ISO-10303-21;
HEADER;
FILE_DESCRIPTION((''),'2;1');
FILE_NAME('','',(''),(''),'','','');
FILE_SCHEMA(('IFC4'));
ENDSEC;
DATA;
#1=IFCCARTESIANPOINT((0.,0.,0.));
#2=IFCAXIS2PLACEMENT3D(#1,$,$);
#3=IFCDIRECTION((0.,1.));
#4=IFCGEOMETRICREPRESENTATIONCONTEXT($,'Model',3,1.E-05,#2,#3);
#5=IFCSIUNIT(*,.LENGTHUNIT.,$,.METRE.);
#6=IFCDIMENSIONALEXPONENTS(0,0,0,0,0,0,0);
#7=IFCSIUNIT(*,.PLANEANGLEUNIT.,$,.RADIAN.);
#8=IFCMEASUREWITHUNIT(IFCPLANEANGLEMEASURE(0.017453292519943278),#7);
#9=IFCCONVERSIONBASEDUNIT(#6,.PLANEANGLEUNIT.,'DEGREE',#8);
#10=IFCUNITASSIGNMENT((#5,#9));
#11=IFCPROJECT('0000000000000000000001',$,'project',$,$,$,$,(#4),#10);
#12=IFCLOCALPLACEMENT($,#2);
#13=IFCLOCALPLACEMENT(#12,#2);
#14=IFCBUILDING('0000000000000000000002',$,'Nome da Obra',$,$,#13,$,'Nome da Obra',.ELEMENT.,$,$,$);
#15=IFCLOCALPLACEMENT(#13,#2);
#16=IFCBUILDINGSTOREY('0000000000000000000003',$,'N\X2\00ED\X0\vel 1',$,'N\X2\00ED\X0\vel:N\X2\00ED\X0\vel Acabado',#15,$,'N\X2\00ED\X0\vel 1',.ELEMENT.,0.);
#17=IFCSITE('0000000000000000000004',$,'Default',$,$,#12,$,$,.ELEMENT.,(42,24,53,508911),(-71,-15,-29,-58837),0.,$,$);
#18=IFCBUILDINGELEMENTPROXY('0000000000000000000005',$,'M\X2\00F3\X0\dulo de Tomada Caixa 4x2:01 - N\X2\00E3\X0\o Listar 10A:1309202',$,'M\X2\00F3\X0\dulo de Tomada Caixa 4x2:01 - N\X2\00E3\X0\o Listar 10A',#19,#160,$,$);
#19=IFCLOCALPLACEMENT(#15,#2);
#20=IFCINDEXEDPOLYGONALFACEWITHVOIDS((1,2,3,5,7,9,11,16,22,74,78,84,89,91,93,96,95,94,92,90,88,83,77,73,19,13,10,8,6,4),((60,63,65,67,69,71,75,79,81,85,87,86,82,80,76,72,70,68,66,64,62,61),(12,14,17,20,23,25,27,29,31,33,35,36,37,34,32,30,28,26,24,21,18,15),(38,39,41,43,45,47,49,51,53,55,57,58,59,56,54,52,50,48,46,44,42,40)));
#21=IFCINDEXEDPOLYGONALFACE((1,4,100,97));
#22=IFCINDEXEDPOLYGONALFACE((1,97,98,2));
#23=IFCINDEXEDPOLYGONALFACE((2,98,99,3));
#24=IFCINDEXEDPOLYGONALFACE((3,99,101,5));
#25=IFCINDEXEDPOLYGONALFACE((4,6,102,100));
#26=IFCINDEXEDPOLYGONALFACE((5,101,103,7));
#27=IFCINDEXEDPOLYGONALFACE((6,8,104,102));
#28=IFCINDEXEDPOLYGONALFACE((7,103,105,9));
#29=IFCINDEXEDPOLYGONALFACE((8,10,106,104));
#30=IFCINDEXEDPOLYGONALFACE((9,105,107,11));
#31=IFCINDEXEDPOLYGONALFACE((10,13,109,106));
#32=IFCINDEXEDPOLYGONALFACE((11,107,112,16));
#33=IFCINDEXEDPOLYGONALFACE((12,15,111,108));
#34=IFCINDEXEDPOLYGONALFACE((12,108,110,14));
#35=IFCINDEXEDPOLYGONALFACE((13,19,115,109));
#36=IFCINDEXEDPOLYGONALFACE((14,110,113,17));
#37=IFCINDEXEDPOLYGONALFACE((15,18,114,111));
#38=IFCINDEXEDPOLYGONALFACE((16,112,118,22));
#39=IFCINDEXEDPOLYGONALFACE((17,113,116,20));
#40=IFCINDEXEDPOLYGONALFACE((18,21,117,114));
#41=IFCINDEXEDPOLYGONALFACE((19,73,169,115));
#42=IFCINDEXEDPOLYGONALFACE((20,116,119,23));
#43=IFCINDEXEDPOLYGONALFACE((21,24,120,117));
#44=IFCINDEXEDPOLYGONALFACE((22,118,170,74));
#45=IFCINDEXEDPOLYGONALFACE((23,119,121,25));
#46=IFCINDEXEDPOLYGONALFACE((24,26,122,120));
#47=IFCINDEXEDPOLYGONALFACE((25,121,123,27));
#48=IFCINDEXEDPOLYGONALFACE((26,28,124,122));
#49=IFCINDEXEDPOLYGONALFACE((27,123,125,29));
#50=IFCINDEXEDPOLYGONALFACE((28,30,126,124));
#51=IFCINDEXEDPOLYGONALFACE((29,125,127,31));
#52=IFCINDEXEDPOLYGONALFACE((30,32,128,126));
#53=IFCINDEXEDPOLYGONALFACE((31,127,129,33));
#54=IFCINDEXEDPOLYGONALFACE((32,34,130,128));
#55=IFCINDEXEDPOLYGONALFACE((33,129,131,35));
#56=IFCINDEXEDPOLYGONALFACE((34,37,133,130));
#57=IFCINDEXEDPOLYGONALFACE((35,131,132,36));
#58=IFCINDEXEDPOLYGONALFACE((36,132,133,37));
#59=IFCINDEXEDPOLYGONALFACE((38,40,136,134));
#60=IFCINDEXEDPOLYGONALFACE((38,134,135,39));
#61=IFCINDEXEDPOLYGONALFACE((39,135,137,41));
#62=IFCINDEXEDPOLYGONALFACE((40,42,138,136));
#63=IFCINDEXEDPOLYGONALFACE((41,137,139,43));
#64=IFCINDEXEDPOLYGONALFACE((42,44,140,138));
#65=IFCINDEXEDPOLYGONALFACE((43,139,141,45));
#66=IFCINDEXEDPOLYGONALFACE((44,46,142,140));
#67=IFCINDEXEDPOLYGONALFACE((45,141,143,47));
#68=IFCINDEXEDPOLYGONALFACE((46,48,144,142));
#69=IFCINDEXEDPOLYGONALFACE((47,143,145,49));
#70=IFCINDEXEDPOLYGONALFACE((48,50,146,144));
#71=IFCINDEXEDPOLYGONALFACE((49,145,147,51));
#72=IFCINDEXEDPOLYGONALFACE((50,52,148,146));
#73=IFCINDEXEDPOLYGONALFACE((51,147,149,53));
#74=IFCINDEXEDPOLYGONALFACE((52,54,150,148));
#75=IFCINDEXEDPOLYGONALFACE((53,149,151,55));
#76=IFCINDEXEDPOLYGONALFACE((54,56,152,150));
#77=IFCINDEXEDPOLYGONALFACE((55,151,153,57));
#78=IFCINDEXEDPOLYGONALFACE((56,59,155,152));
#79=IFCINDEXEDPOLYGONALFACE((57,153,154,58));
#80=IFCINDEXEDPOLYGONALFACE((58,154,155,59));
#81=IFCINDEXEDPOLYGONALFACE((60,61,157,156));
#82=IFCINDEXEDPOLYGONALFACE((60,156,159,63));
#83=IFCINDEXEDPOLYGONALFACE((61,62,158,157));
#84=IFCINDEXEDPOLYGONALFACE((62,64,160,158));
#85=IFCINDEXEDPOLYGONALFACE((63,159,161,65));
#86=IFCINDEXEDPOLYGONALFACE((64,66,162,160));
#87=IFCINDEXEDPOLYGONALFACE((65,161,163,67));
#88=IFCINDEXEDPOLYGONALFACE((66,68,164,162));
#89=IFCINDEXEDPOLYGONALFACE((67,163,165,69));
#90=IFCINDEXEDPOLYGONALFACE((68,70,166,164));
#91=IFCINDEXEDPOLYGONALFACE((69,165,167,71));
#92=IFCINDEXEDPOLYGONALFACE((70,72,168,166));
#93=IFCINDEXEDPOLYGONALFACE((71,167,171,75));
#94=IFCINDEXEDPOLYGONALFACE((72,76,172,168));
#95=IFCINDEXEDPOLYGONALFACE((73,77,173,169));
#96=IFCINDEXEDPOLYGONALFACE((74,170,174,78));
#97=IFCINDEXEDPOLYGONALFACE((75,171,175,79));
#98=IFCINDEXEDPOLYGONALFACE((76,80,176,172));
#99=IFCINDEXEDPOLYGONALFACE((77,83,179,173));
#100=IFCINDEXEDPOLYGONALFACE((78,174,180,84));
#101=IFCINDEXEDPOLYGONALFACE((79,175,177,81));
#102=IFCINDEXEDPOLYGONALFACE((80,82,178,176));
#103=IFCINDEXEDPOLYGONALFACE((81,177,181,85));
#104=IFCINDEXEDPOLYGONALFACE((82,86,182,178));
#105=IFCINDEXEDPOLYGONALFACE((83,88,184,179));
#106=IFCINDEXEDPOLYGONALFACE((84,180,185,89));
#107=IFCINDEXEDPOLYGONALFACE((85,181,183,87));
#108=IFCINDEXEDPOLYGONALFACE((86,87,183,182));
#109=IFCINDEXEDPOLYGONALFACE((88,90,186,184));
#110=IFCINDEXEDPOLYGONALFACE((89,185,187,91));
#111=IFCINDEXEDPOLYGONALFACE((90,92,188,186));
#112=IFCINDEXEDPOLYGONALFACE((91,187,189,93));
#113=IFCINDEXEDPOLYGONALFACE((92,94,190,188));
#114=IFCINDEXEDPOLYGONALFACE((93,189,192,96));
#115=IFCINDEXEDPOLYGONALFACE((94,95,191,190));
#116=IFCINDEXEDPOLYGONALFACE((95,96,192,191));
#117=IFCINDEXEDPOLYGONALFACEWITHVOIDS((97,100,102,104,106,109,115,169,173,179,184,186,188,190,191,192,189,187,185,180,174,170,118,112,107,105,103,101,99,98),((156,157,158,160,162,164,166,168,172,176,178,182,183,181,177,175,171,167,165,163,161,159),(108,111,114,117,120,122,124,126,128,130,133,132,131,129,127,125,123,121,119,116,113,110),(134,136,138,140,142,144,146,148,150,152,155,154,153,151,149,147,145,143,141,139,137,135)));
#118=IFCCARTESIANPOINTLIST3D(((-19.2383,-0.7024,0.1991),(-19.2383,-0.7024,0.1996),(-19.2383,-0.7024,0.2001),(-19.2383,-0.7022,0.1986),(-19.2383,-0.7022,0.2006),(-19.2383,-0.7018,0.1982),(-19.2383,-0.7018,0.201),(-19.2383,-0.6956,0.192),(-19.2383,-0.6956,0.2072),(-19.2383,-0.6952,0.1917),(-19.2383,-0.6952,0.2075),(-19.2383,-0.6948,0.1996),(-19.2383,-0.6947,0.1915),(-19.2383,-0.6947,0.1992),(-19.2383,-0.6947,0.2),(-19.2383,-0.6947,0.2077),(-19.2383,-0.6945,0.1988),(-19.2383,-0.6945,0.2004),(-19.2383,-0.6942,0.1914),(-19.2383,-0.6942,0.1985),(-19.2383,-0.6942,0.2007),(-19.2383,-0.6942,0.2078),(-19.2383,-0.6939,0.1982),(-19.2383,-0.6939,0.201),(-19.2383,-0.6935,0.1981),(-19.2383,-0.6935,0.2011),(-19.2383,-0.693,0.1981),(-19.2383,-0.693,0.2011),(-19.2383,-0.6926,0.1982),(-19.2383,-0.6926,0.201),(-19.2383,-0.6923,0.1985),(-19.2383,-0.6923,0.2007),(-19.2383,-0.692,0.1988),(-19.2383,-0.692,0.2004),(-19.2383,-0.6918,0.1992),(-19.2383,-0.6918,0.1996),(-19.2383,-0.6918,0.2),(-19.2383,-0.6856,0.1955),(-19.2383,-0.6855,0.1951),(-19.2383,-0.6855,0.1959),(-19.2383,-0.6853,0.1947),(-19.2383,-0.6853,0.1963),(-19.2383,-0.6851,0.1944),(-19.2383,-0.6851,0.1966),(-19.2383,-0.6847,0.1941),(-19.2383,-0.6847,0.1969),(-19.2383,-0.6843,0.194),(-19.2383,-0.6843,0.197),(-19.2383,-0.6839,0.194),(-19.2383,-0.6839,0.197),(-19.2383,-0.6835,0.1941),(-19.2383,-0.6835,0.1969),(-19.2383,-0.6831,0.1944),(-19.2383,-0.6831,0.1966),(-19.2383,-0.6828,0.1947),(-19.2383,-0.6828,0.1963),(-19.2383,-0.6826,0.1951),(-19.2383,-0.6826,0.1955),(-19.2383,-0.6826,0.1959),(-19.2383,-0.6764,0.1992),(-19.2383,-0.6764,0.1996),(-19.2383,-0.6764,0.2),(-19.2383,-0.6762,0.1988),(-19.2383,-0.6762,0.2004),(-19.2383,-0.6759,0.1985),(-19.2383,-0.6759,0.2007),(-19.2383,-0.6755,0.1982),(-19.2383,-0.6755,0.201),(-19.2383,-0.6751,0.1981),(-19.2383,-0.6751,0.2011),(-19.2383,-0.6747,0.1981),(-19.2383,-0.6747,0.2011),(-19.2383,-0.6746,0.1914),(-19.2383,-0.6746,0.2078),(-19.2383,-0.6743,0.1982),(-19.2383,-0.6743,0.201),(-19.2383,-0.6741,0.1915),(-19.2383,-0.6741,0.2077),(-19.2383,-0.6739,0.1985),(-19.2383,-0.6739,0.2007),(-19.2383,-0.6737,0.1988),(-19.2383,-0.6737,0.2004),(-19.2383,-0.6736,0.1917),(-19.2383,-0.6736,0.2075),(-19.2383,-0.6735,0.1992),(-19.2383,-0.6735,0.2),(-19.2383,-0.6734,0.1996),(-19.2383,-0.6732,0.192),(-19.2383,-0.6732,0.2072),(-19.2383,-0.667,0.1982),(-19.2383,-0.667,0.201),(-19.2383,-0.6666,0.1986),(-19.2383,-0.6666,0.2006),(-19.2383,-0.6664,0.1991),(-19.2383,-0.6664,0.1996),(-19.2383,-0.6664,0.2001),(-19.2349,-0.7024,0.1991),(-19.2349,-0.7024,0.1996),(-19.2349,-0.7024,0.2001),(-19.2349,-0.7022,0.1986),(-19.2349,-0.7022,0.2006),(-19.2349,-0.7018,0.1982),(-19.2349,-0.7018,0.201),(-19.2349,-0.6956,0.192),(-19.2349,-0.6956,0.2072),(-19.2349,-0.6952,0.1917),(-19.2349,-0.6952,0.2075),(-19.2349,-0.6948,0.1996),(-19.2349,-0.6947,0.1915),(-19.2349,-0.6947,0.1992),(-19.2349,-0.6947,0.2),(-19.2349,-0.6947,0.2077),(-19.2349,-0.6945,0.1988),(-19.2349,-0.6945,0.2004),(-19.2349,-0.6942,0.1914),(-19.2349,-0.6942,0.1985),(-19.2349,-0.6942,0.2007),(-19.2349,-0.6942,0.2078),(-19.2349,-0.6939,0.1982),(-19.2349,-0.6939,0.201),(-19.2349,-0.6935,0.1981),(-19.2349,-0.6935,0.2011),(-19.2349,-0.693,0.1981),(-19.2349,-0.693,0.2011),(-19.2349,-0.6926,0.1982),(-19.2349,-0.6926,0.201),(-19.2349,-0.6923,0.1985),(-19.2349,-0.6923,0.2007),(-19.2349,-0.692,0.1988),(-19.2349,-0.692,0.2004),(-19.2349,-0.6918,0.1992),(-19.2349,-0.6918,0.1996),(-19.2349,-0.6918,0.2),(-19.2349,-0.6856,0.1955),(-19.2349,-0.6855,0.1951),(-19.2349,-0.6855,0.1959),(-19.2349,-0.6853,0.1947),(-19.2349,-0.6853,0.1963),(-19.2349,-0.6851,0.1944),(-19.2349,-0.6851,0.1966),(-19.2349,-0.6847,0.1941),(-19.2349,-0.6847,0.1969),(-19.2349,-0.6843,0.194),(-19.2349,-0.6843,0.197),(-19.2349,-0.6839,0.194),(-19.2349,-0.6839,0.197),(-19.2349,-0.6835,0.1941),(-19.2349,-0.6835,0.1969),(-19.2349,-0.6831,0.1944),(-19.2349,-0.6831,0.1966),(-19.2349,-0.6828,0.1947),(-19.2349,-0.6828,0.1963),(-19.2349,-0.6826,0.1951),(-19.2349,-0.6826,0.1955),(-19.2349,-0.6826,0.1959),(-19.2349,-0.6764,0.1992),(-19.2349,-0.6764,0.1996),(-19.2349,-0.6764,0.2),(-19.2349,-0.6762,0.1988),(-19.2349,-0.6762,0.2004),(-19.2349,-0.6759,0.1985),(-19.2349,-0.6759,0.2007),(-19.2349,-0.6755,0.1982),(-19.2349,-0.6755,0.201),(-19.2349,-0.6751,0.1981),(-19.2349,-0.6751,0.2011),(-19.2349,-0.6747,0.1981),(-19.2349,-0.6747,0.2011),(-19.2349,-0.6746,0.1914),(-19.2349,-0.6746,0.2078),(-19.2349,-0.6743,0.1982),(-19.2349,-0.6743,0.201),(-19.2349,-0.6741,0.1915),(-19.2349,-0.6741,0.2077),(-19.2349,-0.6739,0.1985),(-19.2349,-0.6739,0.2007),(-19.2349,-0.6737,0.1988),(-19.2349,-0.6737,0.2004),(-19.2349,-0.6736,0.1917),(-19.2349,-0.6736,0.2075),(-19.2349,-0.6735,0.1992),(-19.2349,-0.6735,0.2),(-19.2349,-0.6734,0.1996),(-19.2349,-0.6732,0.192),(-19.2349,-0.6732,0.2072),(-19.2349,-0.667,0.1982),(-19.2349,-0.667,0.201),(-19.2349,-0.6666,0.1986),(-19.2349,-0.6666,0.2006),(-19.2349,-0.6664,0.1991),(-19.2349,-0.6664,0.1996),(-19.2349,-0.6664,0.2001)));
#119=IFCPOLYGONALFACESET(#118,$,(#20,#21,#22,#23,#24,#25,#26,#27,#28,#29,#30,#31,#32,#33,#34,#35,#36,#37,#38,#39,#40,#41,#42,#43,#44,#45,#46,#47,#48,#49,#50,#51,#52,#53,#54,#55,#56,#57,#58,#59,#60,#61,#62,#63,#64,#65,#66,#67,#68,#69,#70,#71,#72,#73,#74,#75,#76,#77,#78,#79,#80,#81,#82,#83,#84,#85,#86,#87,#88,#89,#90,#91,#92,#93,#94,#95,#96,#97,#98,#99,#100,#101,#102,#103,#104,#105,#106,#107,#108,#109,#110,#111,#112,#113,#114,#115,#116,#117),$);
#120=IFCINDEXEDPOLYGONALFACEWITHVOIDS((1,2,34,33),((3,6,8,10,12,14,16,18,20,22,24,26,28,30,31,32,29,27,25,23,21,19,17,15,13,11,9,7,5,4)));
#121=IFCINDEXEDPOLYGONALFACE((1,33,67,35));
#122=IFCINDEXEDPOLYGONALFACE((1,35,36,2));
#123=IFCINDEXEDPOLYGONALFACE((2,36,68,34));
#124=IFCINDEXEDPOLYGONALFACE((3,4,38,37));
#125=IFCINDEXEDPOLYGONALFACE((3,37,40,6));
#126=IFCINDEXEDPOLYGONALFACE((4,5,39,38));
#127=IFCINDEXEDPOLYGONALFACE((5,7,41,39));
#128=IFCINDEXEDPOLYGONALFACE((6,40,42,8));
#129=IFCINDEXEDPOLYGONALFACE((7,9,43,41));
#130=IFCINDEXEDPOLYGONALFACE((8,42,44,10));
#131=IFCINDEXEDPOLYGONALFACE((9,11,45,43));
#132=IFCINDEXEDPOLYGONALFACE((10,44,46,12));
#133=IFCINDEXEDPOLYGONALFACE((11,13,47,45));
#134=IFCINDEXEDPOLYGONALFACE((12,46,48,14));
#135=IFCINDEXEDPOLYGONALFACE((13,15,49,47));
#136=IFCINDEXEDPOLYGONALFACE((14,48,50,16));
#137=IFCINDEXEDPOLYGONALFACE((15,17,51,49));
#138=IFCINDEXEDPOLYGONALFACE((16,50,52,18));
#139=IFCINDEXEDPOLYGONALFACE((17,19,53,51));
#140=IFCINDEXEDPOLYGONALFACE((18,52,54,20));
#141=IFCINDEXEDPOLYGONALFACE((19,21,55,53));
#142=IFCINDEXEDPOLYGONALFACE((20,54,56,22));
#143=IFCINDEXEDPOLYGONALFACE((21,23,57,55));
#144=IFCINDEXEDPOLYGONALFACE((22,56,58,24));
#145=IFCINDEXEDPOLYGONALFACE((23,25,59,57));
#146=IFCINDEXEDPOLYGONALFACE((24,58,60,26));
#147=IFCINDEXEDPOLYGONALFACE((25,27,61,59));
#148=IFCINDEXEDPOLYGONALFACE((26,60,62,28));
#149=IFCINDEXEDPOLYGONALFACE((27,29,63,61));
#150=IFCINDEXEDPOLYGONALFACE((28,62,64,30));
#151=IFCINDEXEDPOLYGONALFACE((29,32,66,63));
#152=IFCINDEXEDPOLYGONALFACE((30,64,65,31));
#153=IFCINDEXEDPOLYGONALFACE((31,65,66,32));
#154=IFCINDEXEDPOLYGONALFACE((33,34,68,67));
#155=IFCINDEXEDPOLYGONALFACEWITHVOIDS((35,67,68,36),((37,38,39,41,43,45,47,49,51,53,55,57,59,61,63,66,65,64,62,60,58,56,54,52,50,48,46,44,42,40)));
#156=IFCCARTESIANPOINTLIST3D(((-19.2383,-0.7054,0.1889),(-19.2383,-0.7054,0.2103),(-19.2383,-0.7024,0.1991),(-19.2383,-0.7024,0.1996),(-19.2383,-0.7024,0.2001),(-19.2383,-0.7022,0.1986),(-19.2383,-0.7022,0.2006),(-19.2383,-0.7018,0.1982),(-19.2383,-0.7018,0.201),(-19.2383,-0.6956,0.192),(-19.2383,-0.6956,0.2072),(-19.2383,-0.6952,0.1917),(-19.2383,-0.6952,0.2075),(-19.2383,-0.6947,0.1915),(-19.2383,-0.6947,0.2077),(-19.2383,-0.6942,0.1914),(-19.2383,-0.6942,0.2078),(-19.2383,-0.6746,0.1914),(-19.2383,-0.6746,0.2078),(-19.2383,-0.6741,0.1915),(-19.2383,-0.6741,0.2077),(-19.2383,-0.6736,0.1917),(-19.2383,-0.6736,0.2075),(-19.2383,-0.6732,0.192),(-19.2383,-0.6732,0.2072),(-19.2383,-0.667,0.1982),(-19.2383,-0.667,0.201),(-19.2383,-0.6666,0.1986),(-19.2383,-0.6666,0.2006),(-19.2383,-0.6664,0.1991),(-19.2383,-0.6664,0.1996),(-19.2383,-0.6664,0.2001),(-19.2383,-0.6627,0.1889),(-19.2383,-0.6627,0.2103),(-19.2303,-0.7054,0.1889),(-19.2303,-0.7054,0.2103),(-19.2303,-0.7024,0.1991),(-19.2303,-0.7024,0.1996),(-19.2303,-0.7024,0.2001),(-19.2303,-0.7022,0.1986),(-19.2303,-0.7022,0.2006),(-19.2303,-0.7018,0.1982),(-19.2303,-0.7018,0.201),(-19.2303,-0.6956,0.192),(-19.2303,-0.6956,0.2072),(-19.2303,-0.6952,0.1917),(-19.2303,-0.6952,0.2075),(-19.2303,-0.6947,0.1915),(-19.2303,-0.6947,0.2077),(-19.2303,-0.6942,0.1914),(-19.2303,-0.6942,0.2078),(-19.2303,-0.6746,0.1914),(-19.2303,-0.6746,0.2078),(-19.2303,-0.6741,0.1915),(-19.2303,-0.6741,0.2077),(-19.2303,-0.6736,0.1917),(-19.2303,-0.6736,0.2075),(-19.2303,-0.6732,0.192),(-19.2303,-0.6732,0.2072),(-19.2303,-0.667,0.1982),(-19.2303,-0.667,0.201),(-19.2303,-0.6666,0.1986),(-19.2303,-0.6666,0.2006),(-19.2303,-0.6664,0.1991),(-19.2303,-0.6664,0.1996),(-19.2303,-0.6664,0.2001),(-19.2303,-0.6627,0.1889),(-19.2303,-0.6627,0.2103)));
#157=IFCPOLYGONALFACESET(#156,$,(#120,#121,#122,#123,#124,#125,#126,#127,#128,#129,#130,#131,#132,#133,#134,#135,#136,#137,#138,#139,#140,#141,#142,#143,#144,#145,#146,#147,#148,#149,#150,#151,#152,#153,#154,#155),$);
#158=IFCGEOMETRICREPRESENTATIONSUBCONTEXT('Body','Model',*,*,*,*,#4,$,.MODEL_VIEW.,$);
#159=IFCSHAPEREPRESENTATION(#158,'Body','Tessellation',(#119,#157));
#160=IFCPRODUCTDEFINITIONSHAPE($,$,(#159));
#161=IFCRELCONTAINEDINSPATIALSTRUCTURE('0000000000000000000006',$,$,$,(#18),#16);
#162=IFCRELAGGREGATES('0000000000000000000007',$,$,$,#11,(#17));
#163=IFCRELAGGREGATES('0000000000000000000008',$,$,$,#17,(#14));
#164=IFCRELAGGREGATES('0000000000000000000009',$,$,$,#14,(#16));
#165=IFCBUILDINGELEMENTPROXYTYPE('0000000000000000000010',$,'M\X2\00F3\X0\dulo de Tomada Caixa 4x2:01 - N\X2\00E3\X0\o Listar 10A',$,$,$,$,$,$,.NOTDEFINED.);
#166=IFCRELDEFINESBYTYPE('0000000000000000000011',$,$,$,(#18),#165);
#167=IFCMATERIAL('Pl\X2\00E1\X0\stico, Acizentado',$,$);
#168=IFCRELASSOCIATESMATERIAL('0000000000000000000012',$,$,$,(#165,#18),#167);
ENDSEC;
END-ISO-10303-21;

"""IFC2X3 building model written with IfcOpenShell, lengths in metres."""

from ifc_helpers import new_model, entity, si_unit, converted_unit, direction, frame, frame_2d, origin, place, context, subcontext, project, spatial, polyline, circle_curve, parameter, trimmed, segment, composite_curve, outline, extrude, source, transform, mapped, material, type_object, type_shapes, element, save


model = new_model("IFC2X3")

# Units and contexts
model_context = context("Model", 3, precision=1e-05, world=origin(), true_north=direction((0.0, 1.0)))
body_context = subcontext(model_context, "Body", "Model", "MODEL_VIEW")
ifc_project = project(units=[si_unit("LENGTHUNIT", "METRE"), converted_unit("PLANEANGLEUNIT", "DEGREE", entity("IfcPlaneAngleMeasure", 0.017453292519943278), si_unit("PLANEANGLEUNIT", "RADIAN"), dimensions=[0, 0, 0, 0, 0, 0, 0])], contexts=[model_context])

# Site, building, storey
site_placement = place(None, origin())
site = spatial("IfcSite", under=ifc_project, at=site_placement, Name="Default", CompositionType="ELEMENT", RefLatitude=(42, 24, 53, 508911), RefLongitude=(-71, -15, -29, -58837), RefElevation=0.0)
building_placement = place(site_placement, origin())
building = spatial("IfcBuilding", under=site, at=building_placement, Name="Nome da Obra", LongName="Nome da Obra", CompositionType="ELEMENT")
storey_placement = place(building_placement, origin())
storey = spatial("IfcBuildingStorey", under=building, at=storey_placement, Name="Nível 1", ObjectType="Nível:Nível Acabado", LongName="Nível 1", CompositionType="ELEMENT", Elevation=0.0)

# Building element proxy
ifc_material_1 = material(Name="Plástico, Acizentado")
building_element_proxy_type_1 = type_object("IfcBuildingElementProxyType", Name="Módulo de Tomada Caixa 4x2:01 - Não Listar 10A", PredefinedType="NOTDEFINED", material=ifc_material_1)
shared_shape_1 = source(origin(), body_context, "Body", "SweptSolid", [
    extrude(outline(composite_curve([segment(polyline([(-0.0098, -0.0082), (0.0098, -0.0082)]), True, "CONTINUOUS"), segment(trimmed(circle_curve(frame_2d((0.0098, -0.0062), x_axis=(1.0, 0.0)), 0.002), [parameter(270.0)], [parameter(315.0)], True, "PARAMETER"), True, "CONTINUOUS"), segment(polyline([(0.0112, -0.0076), (0.0174, -0.0014)]), True, "CONTINUOUS"), segment(trimmed(circle_curve(frame_2d((0.016, 0.0), x_axis=(1.0, 0.0)), 0.002), [parameter(315.0)], [parameter(45.0)], True, "PARAMETER"), True, "CONTINUOUS"), segment(polyline([(0.0174, 0.0014), (0.0112, 0.0076)]), True, "CONTINUOUS"), segment(trimmed(circle_curve(frame_2d((0.0098, 0.0062), x_axis=(1.0, 0.0)), 0.002), [parameter(45.0)], [parameter(90.0)], True, "PARAMETER"), True, "CONTINUOUS"), segment(polyline([(0.0098, 0.0082), (-0.0098, 0.0082)]), True, "CONTINUOUS"), segment(trimmed(circle_curve(frame_2d((-0.0098, 0.0062), x_axis=(1.0, 0.0)), 0.002), [parameter(90.0)], [parameter(135.0)], True, "PARAMETER"), True, "CONTINUOUS"), segment(polyline([(-0.0112, 0.0076), (-0.0174, 0.0014)]), True, "CONTINUOUS"), segment(trimmed(circle_curve(frame_2d((-0.016, 0.0), x_axis=(1.0, 0.0)), 0.002), [parameter(135.0)], [parameter(225.0)], True, "PARAMETER"), True, "CONTINUOUS"), segment(polyline([(-0.0174, -0.0014), (-0.0112, -0.0076)]), True, "CONTINUOUS"), segment(trimmed(circle_curve(frame_2d((-0.0098, -0.0062), x_axis=(1.0, 0.0)), 0.002), [parameter(225.0)], [parameter(270.0)], True, "PARAMETER"), True, "CONTINUOUS")], self_intersect=False), holes=[composite_curve([segment(trimmed(circle_curve(frame_2d((0.0089, 0.0), x_axis=(1.0, 0.0)), 0.0015), [parameter(0.0)], [parameter(180.0)], True, "PARAMETER"), False, "CONTINUOUS"), segment(trimmed(circle_curve(frame_2d((0.0089, 0.0), x_axis=(1.0, 0.0)), 0.0015), [parameter(180.0)], [parameter(0.0)], True, "PARAMETER"), False, "CONTINUOUS")], self_intersect=False), composite_curve([segment(trimmed(circle_curve(frame_2d((-0.0003, 0.0041), x_axis=(1.0, 0.0)), 0.0015), [parameter(0.0)], [parameter(180.0)], True, "PARAMETER"), False, "CONTINUOUS"), segment(trimmed(circle_curve(frame_2d((-0.0003, 0.0041), x_axis=(1.0, 0.0)), 0.0015), [parameter(180.0)], [parameter(0.0)], True, "PARAMETER"), False, "CONTINUOUS")], self_intersect=False), composite_curve([segment(trimmed(circle_curve(frame_2d((-0.0095, 0.0), x_axis=(1.0, 0.0)), 0.0015), [parameter(0.0)], [parameter(180.0)], True, "PARAMETER"), False, "CONTINUOUS"), segment(trimmed(circle_curve(frame_2d((-0.0095, 0.0), x_axis=(1.0, 0.0)), 0.0015), [parameter(180.0)], [parameter(0.0)], True, "PARAMETER"), False, "CONTINUOUS")], self_intersect=False)]), frame((0.0003, 0.0, 0.125), z_axis=(0.0, 1.0, 0.0), x_axis=(1.0, 0.0, 0.0)), (0.0, 0.0, 1.0), 0.0034),
    extrude(outline(polyline([(-0.0214, -0.0107), (0.0214, -0.0107), (0.0214, 0.0107), (-0.0214, 0.0107), (-0.0214, -0.0107)]), holes=[composite_curve([segment(polyline([(0.0101, -0.0082), (-0.0095, -0.0082)]), True, "CONTINUOUS"), segment(trimmed(circle_curve(frame_2d((-0.0095, -0.0062), x_axis=(1.0, 0.0)), 0.002), [parameter(225.0)], [parameter(270.0)], True, "PARAMETER"), False, "CONTINUOUS"), segment(polyline([(-0.0109, -0.0076), (-0.0171, -0.0014)]), True, "CONTINUOUS"), segment(trimmed(circle_curve(frame_2d((-0.0157, 0.0), x_axis=(1.0, 0.0)), 0.002), [parameter(135.0)], [parameter(225.0)], True, "PARAMETER"), False, "CONTINUOUS"), segment(polyline([(-0.0171, 0.0014), (-0.0109, 0.0076)]), True, "CONTINUOUS"), segment(trimmed(circle_curve(frame_2d((-0.0095, 0.0062), x_axis=(1.0, 0.0)), 0.002), [parameter(90.0)], [parameter(135.0)], True, "PARAMETER"), False, "CONTINUOUS"), segment(polyline([(-0.0095, 0.0082), (0.0101, 0.0082)]), True, "CONTINUOUS"), segment(trimmed(circle_curve(frame_2d((0.0101, 0.0062), x_axis=(1.0, 0.0)), 0.002), [parameter(45.0)], [parameter(90.0)], True, "PARAMETER"), False, "CONTINUOUS"), segment(polyline([(0.0115, 0.0076), (0.0177, 0.0014)]), True, "CONTINUOUS"), segment(trimmed(circle_curve(frame_2d((0.0163, 0.0), x_axis=(1.0, 0.0)), 0.002), [parameter(315.0)], [parameter(45.0)], True, "PARAMETER"), False, "CONTINUOUS"), segment(polyline([(0.0177, -0.0014), (0.0115, -0.0076)]), True, "CONTINUOUS"), segment(trimmed(circle_curve(frame_2d((0.0101, -0.0062), x_axis=(1.0, 0.0)), 0.002), [parameter(270.0)], [parameter(315.0)], True, "PARAMETER"), False, "CONTINUOUS")], self_intersect=False)]), frame((0.0, 0.0, 0.125), z_axis=(0.0, 1.0, 0.0), x_axis=(1.0, 0.0, 0.0)), (0.0, 0.0, 1.0), 0.008),
])
type_shapes(building_element_proxy_type_1, [shared_shape_1])
for number, where, z_axis, x_axis, name in (
    (1, (-19.2383, -0.6841, 0.0746), (0.0, 0.0, 1.0), (0.0, -1.0, 0.0), "Módulo de Tomada Caixa 4x2:01 - Não Listar 10A:1309202"),
):
    element("IfcBuildingElementProxy", number, at=place(storey_placement, frame(where, z_axis=z_axis, x_axis=x_axis)), inside=storey, type_object=building_element_proxy_type_1, material=ifc_material_1, Name=name, ObjectType="Módulo de Tomada Caixa 4x2:01 - Não Listar 10A", context=body_context, shape_type="MappedRepresentation", body=[
        mapped(shared_shape_1, transform((0.0, 0.0, 0.0), scale=1.0)),
    ])

save(model, "model.ifc")
